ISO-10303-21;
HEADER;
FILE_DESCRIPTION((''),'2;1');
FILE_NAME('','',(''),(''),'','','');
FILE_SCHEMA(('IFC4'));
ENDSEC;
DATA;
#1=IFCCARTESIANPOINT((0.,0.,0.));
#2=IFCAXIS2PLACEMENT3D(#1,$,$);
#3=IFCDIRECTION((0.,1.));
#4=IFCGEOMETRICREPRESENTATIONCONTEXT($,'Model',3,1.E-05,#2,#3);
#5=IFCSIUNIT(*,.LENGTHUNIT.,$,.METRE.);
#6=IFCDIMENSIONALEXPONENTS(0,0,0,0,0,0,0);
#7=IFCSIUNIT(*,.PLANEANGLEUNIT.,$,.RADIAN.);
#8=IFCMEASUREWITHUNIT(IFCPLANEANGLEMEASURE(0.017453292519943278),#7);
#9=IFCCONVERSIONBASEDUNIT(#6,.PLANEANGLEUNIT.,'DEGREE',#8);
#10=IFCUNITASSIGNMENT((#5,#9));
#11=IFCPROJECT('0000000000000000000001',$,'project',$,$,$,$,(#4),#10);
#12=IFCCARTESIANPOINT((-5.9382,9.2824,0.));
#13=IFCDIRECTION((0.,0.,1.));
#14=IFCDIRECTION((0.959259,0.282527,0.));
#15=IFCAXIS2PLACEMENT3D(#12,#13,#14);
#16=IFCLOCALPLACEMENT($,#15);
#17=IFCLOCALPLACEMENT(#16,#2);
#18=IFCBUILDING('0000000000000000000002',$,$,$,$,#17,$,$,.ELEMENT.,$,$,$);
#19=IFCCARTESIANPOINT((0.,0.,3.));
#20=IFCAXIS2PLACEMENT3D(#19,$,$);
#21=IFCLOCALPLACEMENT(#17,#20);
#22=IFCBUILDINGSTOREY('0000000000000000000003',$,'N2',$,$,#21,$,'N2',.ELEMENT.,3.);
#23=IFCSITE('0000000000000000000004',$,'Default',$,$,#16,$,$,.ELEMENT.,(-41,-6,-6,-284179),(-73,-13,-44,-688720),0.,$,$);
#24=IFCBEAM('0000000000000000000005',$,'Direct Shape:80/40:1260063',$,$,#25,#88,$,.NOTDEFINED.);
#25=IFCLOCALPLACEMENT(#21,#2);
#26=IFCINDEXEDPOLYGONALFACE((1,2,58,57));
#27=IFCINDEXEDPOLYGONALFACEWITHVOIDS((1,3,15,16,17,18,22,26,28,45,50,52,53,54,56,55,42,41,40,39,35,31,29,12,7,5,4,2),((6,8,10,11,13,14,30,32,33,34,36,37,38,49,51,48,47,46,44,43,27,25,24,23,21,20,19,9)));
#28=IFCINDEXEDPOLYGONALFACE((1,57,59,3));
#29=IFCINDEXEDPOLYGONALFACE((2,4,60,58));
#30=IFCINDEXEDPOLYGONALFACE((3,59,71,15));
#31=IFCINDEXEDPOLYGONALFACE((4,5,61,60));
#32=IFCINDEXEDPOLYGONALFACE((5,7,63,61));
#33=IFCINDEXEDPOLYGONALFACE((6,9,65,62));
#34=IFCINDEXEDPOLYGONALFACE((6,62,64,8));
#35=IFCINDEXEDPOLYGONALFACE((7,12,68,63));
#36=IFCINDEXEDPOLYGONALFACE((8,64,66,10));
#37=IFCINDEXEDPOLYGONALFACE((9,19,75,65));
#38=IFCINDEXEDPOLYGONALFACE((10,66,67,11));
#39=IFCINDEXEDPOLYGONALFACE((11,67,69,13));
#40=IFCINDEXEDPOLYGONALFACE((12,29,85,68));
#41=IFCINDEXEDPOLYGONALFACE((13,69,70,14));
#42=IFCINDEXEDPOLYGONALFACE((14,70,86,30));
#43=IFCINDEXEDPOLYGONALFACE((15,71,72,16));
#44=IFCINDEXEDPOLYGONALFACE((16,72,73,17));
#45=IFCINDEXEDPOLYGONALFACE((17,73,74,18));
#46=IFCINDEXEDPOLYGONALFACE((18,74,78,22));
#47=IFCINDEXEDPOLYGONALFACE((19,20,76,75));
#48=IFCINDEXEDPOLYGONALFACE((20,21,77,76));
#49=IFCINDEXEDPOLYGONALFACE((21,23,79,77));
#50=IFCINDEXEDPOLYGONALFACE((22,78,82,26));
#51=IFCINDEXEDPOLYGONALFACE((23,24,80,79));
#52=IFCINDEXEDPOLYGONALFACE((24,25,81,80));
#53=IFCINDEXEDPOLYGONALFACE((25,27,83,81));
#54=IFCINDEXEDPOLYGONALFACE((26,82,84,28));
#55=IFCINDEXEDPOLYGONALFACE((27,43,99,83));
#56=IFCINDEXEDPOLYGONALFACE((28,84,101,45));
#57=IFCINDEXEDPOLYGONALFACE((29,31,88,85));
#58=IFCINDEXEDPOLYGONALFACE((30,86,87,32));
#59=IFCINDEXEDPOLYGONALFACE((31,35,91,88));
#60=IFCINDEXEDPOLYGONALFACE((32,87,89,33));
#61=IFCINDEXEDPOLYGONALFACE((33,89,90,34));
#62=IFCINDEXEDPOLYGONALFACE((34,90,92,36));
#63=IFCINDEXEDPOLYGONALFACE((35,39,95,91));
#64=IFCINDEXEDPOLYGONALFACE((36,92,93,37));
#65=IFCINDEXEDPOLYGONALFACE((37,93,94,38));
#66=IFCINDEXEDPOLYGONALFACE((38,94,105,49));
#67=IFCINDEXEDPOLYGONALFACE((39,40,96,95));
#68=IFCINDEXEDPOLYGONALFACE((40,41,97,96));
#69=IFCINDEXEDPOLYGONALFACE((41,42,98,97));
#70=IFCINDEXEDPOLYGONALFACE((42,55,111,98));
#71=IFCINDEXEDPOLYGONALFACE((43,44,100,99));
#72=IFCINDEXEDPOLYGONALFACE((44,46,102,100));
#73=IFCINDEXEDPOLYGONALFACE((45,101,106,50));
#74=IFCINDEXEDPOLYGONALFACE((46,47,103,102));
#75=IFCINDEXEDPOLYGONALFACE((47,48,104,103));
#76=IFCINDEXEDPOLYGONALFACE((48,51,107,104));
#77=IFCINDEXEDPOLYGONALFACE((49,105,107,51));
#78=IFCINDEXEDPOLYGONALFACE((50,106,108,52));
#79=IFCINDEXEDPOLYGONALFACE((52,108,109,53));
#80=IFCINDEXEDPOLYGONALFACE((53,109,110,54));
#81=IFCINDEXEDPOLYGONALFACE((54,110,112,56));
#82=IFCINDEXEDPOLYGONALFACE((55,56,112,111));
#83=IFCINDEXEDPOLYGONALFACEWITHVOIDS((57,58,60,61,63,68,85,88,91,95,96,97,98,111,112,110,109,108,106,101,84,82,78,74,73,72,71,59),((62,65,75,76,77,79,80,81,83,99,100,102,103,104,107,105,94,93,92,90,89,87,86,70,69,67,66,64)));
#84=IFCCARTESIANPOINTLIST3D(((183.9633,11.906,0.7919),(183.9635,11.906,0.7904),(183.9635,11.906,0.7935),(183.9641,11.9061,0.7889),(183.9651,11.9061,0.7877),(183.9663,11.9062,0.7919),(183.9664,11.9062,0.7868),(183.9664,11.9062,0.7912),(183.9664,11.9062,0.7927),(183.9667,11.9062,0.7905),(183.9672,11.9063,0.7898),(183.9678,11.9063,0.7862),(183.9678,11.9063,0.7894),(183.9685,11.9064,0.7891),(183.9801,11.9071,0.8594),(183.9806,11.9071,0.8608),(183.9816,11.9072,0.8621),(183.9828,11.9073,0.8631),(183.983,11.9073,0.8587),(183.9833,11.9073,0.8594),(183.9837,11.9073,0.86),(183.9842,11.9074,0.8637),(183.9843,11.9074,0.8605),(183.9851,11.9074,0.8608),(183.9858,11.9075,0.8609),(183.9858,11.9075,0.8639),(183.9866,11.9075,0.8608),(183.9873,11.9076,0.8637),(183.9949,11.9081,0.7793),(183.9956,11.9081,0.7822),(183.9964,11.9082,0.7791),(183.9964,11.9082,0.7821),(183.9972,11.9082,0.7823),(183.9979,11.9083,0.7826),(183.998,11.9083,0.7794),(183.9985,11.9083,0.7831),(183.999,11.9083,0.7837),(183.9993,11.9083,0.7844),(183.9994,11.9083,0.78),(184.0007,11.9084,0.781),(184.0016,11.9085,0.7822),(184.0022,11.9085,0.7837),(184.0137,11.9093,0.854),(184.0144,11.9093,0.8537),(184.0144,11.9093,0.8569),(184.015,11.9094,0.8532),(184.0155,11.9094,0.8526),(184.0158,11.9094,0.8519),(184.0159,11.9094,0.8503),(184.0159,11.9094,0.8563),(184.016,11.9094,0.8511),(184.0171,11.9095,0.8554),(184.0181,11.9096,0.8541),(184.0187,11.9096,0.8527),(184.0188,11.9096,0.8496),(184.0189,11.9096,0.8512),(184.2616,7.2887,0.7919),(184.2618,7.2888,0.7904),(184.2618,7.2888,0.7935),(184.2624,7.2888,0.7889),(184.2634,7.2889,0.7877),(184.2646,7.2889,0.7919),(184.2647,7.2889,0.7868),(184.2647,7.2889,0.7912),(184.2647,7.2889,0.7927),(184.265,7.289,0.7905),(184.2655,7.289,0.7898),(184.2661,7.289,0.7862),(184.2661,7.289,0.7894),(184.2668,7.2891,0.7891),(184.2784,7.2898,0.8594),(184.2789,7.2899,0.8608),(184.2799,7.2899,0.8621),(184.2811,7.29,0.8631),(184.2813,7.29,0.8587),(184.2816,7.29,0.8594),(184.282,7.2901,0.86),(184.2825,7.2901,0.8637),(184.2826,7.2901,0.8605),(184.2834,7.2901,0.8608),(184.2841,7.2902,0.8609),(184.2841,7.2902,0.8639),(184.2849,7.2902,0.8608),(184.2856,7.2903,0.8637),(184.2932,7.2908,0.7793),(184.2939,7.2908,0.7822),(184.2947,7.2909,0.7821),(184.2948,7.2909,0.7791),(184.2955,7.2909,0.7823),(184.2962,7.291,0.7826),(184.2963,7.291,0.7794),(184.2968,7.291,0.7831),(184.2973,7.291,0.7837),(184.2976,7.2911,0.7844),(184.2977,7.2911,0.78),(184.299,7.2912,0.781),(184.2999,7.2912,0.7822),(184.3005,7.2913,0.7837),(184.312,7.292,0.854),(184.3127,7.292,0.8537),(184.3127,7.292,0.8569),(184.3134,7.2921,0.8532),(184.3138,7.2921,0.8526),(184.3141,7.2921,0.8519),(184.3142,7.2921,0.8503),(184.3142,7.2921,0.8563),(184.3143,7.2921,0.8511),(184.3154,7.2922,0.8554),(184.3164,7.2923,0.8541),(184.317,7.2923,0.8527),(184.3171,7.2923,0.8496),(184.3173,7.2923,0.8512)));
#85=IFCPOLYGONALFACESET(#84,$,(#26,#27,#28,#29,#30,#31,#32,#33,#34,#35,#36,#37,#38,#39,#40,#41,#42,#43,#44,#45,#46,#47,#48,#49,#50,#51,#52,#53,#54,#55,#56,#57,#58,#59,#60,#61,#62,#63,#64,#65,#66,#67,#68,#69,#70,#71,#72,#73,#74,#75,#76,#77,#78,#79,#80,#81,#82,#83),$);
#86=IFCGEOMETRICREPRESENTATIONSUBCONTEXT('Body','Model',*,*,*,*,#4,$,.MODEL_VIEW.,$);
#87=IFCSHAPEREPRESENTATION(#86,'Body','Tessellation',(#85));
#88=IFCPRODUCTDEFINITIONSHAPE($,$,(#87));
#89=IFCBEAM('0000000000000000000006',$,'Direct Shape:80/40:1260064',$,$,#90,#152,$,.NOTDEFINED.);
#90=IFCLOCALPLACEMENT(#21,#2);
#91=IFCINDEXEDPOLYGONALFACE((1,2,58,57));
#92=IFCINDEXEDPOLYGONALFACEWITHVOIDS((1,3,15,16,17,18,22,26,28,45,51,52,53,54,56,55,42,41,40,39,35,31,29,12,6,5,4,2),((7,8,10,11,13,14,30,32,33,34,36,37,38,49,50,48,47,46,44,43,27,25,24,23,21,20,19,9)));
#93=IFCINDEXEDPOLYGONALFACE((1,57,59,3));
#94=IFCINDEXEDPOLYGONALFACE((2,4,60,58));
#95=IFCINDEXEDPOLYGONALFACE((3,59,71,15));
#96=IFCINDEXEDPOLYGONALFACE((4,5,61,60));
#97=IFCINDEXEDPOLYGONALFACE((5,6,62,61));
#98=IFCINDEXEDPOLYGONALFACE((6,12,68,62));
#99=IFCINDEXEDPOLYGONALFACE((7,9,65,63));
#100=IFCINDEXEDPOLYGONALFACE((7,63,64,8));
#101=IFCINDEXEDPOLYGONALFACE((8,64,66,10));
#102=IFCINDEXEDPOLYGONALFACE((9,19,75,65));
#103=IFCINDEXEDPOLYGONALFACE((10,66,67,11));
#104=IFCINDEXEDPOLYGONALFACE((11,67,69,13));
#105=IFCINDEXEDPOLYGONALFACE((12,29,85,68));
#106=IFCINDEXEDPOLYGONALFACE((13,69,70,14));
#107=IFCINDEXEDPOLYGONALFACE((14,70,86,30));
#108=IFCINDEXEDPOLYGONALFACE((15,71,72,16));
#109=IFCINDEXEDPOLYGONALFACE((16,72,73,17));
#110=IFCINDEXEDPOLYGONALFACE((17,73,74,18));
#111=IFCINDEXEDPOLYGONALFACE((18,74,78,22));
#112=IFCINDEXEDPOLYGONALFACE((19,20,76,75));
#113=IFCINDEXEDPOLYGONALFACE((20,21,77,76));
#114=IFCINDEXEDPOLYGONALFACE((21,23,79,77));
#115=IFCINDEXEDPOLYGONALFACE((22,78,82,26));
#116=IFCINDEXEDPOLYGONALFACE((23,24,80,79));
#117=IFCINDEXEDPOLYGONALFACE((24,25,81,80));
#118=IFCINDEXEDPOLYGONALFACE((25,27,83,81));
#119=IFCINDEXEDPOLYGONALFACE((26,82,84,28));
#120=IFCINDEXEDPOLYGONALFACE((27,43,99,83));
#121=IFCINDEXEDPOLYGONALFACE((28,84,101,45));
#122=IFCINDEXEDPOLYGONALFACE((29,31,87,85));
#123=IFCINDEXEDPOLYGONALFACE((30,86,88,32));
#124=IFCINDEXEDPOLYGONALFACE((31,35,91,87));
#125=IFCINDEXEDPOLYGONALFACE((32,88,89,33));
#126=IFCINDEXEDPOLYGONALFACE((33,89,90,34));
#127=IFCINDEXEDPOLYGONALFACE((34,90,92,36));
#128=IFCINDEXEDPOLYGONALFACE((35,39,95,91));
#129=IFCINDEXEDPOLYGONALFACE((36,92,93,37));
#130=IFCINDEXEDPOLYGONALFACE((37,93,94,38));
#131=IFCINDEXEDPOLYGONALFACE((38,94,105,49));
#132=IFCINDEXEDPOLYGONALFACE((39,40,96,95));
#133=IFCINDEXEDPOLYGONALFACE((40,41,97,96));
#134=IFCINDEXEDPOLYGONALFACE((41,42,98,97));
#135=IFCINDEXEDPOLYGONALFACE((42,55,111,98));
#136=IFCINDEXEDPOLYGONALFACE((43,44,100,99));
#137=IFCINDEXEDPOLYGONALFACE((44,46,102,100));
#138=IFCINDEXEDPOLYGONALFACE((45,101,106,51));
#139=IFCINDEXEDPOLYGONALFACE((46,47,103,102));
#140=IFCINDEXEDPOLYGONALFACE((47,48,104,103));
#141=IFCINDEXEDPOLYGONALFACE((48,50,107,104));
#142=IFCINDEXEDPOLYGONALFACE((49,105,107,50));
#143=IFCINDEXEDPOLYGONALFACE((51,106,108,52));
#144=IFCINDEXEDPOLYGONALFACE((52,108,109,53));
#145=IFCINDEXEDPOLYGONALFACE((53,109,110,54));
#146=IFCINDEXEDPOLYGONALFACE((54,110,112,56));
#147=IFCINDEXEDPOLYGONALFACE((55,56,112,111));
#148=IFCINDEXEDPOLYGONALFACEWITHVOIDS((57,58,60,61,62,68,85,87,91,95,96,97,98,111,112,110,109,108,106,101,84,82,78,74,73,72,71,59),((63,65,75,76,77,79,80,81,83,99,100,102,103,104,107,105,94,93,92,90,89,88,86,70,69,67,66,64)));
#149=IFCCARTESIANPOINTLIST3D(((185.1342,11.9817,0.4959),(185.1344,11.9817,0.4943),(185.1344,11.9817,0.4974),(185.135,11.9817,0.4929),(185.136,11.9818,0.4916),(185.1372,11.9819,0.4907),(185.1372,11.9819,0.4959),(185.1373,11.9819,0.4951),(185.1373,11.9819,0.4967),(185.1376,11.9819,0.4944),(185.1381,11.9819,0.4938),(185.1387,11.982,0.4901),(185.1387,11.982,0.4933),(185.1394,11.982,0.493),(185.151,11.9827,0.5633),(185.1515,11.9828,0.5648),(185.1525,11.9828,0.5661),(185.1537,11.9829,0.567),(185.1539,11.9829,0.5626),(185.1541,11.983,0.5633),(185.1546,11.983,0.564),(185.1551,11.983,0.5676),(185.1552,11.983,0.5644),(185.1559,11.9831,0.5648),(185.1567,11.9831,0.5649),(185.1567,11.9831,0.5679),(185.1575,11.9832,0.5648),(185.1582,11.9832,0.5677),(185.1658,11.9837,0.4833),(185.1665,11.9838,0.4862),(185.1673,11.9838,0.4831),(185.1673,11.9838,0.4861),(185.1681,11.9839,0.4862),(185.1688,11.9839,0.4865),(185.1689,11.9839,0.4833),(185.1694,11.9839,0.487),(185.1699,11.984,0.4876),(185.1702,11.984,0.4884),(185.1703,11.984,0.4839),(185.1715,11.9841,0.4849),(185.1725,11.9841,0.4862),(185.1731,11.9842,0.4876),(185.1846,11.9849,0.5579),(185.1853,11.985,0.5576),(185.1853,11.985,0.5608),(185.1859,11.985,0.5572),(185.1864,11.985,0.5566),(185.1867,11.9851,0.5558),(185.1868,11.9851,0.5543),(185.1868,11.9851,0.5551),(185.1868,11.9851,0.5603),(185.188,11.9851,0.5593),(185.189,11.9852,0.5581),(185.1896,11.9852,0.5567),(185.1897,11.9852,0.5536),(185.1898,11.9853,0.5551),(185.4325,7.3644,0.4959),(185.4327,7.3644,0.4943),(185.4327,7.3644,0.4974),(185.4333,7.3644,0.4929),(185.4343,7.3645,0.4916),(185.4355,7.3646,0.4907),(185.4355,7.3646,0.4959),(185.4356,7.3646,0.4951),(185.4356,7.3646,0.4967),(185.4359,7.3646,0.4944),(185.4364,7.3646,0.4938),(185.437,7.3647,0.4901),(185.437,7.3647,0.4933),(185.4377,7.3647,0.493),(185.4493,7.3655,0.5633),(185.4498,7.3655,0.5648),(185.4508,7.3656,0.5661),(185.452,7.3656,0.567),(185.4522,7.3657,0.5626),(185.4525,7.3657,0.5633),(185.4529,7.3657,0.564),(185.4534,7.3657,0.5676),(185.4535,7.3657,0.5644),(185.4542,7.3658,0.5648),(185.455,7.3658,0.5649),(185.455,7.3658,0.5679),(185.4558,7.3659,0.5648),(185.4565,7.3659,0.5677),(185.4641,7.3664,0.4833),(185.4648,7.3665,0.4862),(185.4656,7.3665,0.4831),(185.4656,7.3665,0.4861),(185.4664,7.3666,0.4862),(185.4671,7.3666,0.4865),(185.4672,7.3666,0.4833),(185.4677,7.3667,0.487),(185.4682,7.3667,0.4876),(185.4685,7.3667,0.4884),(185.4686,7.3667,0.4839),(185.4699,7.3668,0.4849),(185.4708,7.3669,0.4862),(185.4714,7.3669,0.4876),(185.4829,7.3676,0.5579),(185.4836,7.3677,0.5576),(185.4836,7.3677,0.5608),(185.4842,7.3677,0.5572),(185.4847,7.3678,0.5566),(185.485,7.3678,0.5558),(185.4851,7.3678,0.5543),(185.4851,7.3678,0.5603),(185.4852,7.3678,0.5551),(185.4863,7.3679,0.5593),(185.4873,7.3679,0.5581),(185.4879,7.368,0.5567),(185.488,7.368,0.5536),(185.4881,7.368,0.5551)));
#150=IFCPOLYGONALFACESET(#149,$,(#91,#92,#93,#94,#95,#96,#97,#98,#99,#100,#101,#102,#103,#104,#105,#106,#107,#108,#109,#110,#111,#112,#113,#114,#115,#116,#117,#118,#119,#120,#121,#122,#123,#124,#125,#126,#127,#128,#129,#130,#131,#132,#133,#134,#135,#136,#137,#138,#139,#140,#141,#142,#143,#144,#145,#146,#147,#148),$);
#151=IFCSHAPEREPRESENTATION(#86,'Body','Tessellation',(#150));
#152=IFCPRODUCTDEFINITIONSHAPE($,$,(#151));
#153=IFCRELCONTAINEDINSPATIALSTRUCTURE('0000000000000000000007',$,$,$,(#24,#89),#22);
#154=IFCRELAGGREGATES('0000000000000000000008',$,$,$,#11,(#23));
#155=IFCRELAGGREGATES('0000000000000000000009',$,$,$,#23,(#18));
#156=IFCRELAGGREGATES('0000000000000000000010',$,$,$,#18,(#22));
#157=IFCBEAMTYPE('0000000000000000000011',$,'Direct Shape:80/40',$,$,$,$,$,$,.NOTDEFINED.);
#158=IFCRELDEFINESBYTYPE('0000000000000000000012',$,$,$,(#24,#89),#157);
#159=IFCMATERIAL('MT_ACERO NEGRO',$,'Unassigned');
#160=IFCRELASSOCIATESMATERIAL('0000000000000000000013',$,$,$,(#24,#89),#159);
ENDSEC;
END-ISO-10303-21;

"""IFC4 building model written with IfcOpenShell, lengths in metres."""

from ifc_helpers import new_model, entity, si_unit, converted_unit, direction, frame, frame_2d, origin, place, context, subcontext, project, spatial, polyline, circle_curve, parameter, trimmed, segment, composite_curve, outline, extrude, material, type_object, element, save


model = new_model("IFC4")

# Units and contexts
model_context = context("Model", 3, precision=1e-05, world=origin(), true_north=direction((0.0, 1.0)))
body_context = subcontext(model_context, "Body", "Model", "MODEL_VIEW")
ifc_project = project(units=[si_unit("LENGTHUNIT", "METRE"), converted_unit("PLANEANGLEUNIT", "DEGREE", entity("IfcPlaneAngleMeasure", 0.017453292519943278), si_unit("PLANEANGLEUNIT", "RADIAN"), dimensions=[0, 0, 0, 0, 0, 0, 0])], contexts=[model_context])

# Site, building, storey
site_placement = place(None, frame((-5.9382, 9.2824, 0.0), z_axis=(0.0, 0.0, 1.0), x_axis=(0.959259, 0.282527, 0.0)))
site = spatial("IfcSite", under=ifc_project, at=site_placement, Name="Default", CompositionType="ELEMENT", RefLatitude=(-41, -6, -6, -284179), RefLongitude=(-73, -13, -44, -688720), RefElevation=0.0)
building_placement = place(site_placement, origin())
building = spatial("IfcBuilding", under=site, at=building_placement, CompositionType="ELEMENT")
storey_placement = place(building_placement, frame((0.0, 0.0, 3.0)))
storey = spatial("IfcBuildingStorey", under=building, at=storey_placement, Name="N2", LongName="N2", CompositionType="ELEMENT", Elevation=3.0)

# Shared definitions
ifc_material = material(Name="MT_ACERO NEGRO", Category="Unassigned")

# Beams
beam_type_1 = type_object("IfcBeamType", Name="Direct Shape:80/40", PredefinedType="NOTDEFINED")
beam_1_placement = place(storey_placement, origin())
element("IfcBeam", 1, at=beam_1_placement, inside=storey, type_object=beam_type_1, material=ifc_material, Name="Direct Shape:80/40:1260063", PredefinedType="NOTDEFINED", context=body_context, shape_type="SweptSolid", body=[
    extrude(outline(composite_curve([segment(polyline([(-0.034, -0.02), (0.034, -0.02)]), True, "CONTINUOUS"), segment(trimmed(circle_curve(frame_2d((0.034, -0.014), x_axis=(0.0, 1.0)), 0.006), [parameter(180.0)], [parameter(270.0)], True, "PARAMETER"), True, "CONTINUOUS"), segment(polyline([(0.04, -0.014), (0.04, 0.014)]), True, "CONTINUOUS"), segment(trimmed(circle_curve(frame_2d((0.034, 0.014), x_axis=(0.0, 1.0)), 0.006), [parameter(270.0)], [parameter(0.0)], True, "PARAMETER"), True, "CONTINUOUS"), segment(polyline([(0.034, 0.02), (-0.034, 0.02)]), True, "CONTINUOUS"), segment(trimmed(circle_curve(frame_2d((-0.034, 0.014), x_axis=(0.0, 1.0)), 0.006), [parameter(0.0)], [parameter(90.0)], True, "PARAMETER"), True, "CONTINUOUS"), segment(polyline([(-0.04, 0.014), (-0.04, -0.014)]), True, "CONTINUOUS"), segment(trimmed(circle_curve(frame_2d((-0.034, -0.014), x_axis=(0.0, 1.0)), 0.006), [parameter(90.0)], [parameter(180.0)], True, "PARAMETER"), True, "CONTINUOUS")], self_intersect=False), holes=[composite_curve([segment(trimmed(circle_curve(frame_2d((-0.034, 0.014), x_axis=(0.0, 1.0)), 0.003), [parameter(360.0)], [parameter(90.0)], True, "PARAMETER"), False, "CONTINUOUS"), segment(polyline([(-0.034, 0.017), (0.034, 0.017)]), True, "CONTINUOUS"), segment(trimmed(circle_curve(frame_2d((0.034, 0.014), x_axis=(0.0, 1.0)), 0.003), [parameter(270.0)], [parameter(0.0)], True, "PARAMETER"), False, "CONTINUOUS"), segment(polyline([(0.037, 0.014), (0.037, -0.014)]), True, "CONTINUOUS"), segment(trimmed(circle_curve(frame_2d((0.034, -0.014), x_axis=(0.0, 1.0)), 0.003), [parameter(180.0)], [parameter(270.0)], True, "PARAMETER"), False, "CONTINUOUS"), segment(polyline([(0.034, -0.017), (-0.034, -0.017)]), True, "CONTINUOUS"), segment(trimmed(circle_curve(frame_2d((-0.034, -0.014), x_axis=(0.0, 1.0)), 0.003), [parameter(90.0)], [parameter(180.0)], True, "PARAMETER"), False, "CONTINUOUS"), segment(polyline([(-0.037, -0.014), (-0.037, 0.014)]), True, "CONTINUOUS")], self_intersect=False)]), frame((184.2894, 7.2905, 0.8215), z_axis=(-0.064471, 0.99792, 0.0), x_axis=(-0.24414, -0.015773, -0.969612)), (0.0, 0.0, 1.0), 4.6269),
])
beam_2_placement = place(storey_placement, origin())
element("IfcBeam", 2, at=beam_2_placement, inside=storey, type_object=beam_type_1, material=ifc_material, Name="Direct Shape:80/40:1260064", PredefinedType="NOTDEFINED", context=body_context, shape_type="SweptSolid", body=[
    extrude(outline(composite_curve([segment(polyline([(-0.034, -0.02), (0.034, -0.02)]), True, "CONTINUOUS"), segment(trimmed(circle_curve(frame_2d((0.034, -0.014), x_axis=(0.0, 1.0)), 0.006), [parameter(180.0)], [parameter(270.0)], True, "PARAMETER"), True, "CONTINUOUS"), segment(polyline([(0.04, -0.014), (0.04, 0.014)]), True, "CONTINUOUS"), segment(trimmed(circle_curve(frame_2d((0.034, 0.014), x_axis=(0.0, 1.0)), 0.006), [parameter(270.0)], [parameter(0.0)], True, "PARAMETER"), True, "CONTINUOUS"), segment(polyline([(0.034, 0.02), (-0.034, 0.02)]), True, "CONTINUOUS"), segment(trimmed(circle_curve(frame_2d((-0.034, 0.014), x_axis=(0.0, 1.0)), 0.006), [parameter(0.0)], [parameter(90.0)], True, "PARAMETER"), True, "CONTINUOUS"), segment(polyline([(-0.04, 0.014), (-0.04, -0.014)]), True, "CONTINUOUS"), segment(trimmed(circle_curve(frame_2d((-0.034, -0.014), x_axis=(0.0, 1.0)), 0.006), [parameter(90.0)], [parameter(180.0)], True, "PARAMETER"), True, "CONTINUOUS")], self_intersect=False), holes=[composite_curve([segment(trimmed(circle_curve(frame_2d((-0.034, 0.014), x_axis=(0.0, 1.0)), 0.003), [parameter(360.0)], [parameter(90.0)], True, "PARAMETER"), False, "CONTINUOUS"), segment(polyline([(-0.034, 0.017), (0.034, 0.017)]), True, "CONTINUOUS"), segment(trimmed(circle_curve(frame_2d((0.034, 0.014), x_axis=(0.0, 1.0)), 0.003), [parameter(270.0)], [parameter(0.0)], True, "PARAMETER"), False, "CONTINUOUS"), segment(polyline([(0.037, 0.014), (0.037, -0.014)]), True, "CONTINUOUS"), segment(trimmed(circle_curve(frame_2d((0.034, -0.014), x_axis=(0.0, 1.0)), 0.003), [parameter(180.0)], [parameter(270.0)], True, "PARAMETER"), False, "CONTINUOUS"), segment(polyline([(0.034, -0.017), (-0.034, -0.017)]), True, "CONTINUOUS"), segment(trimmed(circle_curve(frame_2d((-0.034, -0.014), x_axis=(0.0, 1.0)), 0.003), [parameter(90.0)], [parameter(180.0)], True, "PARAMETER"), False, "CONTINUOUS"), segment(polyline([(-0.037, -0.014), (-0.037, 0.014)]), True, "CONTINUOUS")], self_intersect=False)]), frame((185.4603, 7.3662, 0.5255), z_axis=(-0.064471, 0.99792, 0.0), x_axis=(-0.24414, -0.015773, -0.969612)), (0.0, 0.0, 1.0), 4.6269),
])

save(model, "model.ifc")
